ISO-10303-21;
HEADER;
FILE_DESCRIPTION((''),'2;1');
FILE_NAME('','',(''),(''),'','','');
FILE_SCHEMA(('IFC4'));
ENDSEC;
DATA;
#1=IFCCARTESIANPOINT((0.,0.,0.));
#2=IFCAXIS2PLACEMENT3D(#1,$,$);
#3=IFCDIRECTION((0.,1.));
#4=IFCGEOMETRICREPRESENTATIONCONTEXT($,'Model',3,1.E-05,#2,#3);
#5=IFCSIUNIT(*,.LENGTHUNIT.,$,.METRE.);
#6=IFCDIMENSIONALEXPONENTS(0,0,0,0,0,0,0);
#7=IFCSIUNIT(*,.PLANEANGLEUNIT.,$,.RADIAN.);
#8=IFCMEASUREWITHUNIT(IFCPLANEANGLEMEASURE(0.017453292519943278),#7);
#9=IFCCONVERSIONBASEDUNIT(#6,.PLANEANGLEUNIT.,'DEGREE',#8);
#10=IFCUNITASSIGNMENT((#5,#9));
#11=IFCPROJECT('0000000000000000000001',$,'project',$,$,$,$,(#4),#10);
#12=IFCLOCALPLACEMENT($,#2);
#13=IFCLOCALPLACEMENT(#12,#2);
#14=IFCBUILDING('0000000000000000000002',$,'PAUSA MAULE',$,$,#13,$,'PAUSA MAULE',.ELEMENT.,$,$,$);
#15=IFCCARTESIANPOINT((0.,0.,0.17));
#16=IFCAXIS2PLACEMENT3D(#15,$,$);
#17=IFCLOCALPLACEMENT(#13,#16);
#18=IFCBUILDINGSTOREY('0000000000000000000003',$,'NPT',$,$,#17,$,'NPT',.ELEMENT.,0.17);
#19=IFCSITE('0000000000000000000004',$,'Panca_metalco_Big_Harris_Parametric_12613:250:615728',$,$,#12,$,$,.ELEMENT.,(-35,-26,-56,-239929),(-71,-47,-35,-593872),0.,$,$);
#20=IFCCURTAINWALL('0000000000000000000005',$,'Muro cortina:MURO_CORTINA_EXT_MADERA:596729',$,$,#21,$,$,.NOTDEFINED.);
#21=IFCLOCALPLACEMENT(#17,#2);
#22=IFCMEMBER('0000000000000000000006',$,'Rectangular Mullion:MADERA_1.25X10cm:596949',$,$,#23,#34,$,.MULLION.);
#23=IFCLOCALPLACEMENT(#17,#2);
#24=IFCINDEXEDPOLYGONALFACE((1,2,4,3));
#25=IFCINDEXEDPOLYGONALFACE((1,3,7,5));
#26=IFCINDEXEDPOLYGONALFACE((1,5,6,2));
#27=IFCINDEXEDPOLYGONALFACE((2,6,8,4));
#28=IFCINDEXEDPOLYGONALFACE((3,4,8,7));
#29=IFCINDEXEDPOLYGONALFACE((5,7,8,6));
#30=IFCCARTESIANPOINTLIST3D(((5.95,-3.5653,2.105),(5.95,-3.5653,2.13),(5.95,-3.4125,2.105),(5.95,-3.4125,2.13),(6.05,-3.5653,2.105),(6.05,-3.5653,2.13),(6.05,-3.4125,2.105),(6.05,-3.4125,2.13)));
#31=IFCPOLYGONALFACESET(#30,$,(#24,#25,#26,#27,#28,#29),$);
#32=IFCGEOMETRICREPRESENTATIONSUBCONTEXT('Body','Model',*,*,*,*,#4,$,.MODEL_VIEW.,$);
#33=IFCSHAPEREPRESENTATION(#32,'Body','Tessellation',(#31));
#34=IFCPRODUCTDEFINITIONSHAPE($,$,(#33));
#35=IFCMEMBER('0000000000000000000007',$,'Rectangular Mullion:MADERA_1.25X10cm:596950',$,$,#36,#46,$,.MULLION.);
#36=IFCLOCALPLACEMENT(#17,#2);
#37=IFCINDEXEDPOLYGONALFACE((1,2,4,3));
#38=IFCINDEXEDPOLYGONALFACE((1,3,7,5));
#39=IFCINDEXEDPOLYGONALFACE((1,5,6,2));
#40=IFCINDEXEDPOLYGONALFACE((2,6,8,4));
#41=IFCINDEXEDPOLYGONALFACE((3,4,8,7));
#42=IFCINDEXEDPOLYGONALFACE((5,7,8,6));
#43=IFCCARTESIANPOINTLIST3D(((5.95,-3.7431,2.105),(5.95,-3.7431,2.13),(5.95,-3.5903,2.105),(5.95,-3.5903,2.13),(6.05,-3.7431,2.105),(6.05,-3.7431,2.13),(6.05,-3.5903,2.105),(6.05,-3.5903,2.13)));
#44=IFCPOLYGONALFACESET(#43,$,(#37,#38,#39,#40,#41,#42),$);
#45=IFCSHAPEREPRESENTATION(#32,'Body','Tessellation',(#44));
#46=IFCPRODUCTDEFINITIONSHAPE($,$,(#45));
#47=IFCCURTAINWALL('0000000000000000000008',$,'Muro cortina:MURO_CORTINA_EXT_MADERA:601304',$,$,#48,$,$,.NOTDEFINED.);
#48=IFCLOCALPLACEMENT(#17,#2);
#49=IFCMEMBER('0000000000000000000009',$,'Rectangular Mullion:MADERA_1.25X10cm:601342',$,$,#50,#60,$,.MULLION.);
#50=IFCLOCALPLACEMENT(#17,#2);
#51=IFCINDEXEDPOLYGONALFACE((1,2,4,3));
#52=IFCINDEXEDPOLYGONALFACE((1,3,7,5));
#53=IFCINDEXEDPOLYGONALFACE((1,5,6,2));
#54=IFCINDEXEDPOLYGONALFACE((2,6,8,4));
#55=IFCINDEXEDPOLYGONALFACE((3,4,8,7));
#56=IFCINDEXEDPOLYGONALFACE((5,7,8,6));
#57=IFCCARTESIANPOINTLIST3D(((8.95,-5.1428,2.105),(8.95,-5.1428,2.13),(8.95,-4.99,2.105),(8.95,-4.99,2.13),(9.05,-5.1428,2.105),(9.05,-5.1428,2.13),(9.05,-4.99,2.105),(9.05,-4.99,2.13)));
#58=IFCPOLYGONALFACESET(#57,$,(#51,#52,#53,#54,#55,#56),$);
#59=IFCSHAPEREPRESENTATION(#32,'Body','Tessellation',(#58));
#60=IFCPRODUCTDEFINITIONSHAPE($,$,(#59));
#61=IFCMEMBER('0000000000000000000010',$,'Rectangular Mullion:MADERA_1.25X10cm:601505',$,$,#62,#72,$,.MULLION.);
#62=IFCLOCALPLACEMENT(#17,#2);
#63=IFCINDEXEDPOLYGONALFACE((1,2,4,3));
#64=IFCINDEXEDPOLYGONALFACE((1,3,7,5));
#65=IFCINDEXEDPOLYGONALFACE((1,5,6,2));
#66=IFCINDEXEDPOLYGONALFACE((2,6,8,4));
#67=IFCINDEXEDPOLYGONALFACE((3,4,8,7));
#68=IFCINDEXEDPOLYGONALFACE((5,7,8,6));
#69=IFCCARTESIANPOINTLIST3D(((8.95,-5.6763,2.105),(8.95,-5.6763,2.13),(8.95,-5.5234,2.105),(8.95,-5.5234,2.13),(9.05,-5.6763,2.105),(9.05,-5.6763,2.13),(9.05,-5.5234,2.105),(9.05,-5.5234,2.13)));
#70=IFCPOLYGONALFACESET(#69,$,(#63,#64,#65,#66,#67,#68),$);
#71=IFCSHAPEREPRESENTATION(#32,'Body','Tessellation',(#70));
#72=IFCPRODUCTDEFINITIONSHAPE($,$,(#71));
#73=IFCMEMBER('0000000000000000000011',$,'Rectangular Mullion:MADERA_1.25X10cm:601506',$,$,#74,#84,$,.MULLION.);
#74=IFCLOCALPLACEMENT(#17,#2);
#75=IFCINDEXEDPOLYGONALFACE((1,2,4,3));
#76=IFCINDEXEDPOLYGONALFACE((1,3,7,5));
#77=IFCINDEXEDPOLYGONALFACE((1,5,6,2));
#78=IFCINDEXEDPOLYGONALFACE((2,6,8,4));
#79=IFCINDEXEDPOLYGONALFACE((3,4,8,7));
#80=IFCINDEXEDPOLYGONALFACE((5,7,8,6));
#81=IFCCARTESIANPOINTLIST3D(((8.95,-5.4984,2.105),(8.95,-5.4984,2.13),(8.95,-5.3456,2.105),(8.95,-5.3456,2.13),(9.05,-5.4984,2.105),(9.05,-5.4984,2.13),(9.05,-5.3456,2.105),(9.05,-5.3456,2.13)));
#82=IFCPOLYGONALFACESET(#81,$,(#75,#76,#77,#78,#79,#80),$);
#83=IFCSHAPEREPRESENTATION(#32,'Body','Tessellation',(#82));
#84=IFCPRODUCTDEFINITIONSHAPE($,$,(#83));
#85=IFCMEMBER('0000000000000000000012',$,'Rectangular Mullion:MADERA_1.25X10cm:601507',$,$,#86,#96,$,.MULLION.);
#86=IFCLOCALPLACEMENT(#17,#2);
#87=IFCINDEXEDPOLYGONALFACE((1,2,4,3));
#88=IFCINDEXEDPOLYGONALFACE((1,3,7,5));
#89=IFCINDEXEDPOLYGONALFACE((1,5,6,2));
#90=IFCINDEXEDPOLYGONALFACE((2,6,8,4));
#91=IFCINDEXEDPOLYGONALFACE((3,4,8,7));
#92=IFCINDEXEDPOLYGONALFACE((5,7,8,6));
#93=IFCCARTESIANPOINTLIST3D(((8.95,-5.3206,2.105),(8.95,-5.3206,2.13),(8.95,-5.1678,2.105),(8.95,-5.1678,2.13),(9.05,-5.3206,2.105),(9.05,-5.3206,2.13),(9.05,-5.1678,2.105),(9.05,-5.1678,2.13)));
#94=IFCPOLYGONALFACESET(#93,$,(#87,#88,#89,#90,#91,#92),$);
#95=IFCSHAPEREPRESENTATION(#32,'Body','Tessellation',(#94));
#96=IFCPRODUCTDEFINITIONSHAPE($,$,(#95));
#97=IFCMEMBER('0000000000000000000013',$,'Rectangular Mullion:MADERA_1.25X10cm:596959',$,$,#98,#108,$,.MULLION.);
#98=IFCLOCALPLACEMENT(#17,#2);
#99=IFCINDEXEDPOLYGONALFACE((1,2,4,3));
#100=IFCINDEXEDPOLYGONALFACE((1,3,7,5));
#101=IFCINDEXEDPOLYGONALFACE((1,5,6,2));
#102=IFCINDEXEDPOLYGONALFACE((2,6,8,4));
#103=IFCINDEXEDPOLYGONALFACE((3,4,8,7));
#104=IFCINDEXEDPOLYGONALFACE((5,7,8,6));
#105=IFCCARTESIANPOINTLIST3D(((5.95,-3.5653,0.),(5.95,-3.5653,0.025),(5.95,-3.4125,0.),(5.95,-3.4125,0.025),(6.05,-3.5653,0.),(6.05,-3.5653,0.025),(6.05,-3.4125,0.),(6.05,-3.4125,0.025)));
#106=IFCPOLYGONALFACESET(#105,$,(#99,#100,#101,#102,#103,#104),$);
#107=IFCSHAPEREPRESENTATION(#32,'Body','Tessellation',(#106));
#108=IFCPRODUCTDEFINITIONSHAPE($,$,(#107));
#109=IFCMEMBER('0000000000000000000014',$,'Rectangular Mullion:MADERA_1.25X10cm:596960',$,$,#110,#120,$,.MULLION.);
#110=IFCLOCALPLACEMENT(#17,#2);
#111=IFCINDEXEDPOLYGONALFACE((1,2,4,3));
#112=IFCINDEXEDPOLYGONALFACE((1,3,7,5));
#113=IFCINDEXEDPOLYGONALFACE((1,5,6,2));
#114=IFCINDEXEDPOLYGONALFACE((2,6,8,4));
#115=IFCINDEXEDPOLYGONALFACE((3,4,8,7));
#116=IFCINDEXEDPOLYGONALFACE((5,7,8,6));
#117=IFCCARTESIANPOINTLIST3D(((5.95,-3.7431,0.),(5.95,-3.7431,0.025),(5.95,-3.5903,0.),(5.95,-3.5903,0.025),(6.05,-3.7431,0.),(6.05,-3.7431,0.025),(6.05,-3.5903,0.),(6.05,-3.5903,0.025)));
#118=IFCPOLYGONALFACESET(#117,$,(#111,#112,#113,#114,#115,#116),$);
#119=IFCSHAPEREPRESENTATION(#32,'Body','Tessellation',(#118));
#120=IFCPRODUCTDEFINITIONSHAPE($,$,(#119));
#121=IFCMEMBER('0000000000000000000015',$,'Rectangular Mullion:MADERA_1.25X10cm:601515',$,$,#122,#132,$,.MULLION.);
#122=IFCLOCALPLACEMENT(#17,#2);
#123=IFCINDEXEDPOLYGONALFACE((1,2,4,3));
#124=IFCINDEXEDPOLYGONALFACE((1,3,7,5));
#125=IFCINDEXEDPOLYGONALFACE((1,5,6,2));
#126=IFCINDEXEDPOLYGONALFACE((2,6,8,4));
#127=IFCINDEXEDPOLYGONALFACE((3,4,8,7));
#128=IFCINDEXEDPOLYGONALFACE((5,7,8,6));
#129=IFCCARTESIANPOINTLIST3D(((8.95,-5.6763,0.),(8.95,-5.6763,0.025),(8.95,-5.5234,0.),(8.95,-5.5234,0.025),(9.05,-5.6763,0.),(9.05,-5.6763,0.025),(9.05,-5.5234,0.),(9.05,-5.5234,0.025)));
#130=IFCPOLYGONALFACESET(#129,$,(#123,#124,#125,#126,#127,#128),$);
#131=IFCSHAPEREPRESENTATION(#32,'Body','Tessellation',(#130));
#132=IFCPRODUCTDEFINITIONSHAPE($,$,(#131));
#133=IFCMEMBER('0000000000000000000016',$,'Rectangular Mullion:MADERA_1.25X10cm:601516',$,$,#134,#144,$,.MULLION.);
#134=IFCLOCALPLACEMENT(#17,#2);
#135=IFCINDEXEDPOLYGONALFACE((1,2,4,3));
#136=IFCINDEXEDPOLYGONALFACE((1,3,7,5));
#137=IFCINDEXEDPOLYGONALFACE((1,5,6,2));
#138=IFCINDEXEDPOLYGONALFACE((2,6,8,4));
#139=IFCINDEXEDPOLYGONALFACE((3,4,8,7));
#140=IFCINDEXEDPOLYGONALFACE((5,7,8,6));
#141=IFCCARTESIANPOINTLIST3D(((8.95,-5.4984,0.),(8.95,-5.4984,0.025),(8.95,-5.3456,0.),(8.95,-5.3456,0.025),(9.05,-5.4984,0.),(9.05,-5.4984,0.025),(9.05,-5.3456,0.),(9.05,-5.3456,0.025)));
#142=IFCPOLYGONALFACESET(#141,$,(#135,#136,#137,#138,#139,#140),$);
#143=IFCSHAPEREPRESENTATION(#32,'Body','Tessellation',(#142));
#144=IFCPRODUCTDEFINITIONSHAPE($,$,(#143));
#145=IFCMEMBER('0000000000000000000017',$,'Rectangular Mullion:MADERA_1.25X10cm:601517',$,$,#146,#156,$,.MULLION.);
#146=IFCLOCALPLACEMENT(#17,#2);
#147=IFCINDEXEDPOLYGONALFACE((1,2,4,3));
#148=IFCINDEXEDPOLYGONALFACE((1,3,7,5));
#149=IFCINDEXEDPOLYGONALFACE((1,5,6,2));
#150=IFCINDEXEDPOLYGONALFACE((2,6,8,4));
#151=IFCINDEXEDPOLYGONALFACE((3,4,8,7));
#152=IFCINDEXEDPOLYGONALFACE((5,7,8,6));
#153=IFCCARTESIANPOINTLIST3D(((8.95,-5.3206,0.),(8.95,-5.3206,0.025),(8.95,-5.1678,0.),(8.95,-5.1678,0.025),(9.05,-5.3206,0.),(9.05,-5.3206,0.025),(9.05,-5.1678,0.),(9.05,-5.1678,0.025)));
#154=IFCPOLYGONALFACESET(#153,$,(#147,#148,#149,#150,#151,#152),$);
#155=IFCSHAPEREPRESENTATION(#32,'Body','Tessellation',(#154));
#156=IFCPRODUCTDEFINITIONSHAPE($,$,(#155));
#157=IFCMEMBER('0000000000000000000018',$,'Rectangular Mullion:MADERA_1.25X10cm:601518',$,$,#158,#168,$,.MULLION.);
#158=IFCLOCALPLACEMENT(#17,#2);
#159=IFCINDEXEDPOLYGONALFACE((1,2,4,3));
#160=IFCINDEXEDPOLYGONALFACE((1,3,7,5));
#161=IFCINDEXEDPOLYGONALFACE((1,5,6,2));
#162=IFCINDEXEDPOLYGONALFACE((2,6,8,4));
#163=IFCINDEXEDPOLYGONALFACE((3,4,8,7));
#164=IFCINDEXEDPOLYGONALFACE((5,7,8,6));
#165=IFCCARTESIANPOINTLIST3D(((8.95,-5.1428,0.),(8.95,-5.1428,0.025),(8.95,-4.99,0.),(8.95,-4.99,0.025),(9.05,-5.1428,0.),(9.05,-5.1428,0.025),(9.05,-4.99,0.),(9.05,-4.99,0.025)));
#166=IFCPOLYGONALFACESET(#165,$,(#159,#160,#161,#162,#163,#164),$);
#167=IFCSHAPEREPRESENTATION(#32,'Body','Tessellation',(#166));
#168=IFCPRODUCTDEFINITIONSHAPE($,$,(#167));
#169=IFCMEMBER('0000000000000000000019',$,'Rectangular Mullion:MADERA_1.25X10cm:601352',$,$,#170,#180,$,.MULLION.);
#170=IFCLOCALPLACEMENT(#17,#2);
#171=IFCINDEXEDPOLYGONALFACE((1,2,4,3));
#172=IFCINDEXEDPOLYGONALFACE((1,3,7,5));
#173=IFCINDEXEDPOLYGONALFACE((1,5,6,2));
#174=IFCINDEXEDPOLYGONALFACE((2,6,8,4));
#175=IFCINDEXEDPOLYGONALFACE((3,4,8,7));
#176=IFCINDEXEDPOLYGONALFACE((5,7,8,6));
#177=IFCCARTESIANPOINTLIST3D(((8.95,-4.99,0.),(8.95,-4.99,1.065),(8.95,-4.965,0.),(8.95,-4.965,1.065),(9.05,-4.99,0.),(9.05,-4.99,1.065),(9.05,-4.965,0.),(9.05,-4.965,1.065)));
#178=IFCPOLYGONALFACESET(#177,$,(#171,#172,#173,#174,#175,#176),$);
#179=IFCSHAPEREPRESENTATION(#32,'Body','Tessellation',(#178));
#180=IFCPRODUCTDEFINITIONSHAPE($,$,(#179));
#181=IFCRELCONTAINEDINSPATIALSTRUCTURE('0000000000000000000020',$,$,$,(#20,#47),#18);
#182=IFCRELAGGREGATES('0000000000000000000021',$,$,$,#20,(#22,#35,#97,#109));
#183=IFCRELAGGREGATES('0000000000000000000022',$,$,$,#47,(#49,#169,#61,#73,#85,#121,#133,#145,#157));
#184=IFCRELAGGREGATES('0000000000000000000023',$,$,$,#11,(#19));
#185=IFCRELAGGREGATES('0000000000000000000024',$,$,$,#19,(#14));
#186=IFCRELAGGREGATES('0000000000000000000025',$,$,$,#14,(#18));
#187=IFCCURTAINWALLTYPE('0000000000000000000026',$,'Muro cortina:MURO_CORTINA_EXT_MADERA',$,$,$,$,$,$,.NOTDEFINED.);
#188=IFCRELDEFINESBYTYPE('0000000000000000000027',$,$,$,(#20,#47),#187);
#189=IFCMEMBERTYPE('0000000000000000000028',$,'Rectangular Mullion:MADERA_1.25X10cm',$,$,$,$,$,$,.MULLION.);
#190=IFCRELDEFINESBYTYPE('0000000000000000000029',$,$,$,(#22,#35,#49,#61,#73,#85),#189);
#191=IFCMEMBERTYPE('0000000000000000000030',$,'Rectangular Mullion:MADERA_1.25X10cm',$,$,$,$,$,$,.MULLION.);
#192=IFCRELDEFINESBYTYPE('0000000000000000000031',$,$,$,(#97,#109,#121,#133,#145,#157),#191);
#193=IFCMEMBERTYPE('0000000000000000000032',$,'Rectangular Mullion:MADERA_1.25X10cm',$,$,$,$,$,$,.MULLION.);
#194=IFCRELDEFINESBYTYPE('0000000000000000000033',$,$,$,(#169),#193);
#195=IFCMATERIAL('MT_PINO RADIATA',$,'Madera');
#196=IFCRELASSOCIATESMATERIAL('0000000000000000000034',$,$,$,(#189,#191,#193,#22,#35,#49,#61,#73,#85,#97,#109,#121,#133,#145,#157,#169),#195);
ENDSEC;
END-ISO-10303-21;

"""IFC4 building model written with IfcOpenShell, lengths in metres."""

from ifc_helpers import new_model, entity, si_unit, converted_unit, direction, frame, frame_2d, origin, origin_2d_with_axis, place, context, subcontext, project, spatial, rectangle, extrude, source, transform, mapped, material, material_profile, profile_set, profile_usage, type_object, type_shapes, element, aggregate, save


model = new_model("IFC4")

# Units and contexts
model_context = context("Model", 3, precision=1e-05, world=origin(), true_north=direction((0.0, 1.0)))
body_context = subcontext(model_context, "Body", "Model", "MODEL_VIEW")
ifc_project = project(units=[si_unit("LENGTHUNIT", "METRE"), converted_unit("PLANEANGLEUNIT", "DEGREE", entity("IfcPlaneAngleMeasure", 0.017453292519943278), si_unit("PLANEANGLEUNIT", "RADIAN"), dimensions=[0, 0, 0, 0, 0, 0, 0])], contexts=[model_context])

# Site, building, storey
site_placement = place(None, origin())
site = spatial("IfcSite", under=ifc_project, at=site_placement, Name="Panca_metalco_Big_Harris_Parametric_12613:250:615728", CompositionType="ELEMENT", RefLatitude=(-35, -26, -56, -239929), RefLongitude=(-71, -47, -35, -593872), RefElevation=0.0)
building_placement = place(site_placement, origin())
building = spatial("IfcBuilding", under=site, at=building_placement, Name="PAUSA MAULE", LongName="PAUSA MAULE", CompositionType="ELEMENT")
storey_placement = place(building_placement, frame((0.0, 0.0, 0.17)))
storey = spatial("IfcBuildingStorey", under=building, at=storey_placement, Name="NPT", LongName="NPT", CompositionType="ELEMENT", Elevation=0.17)

# Curtain walls, members
curtain_wall_type = type_object("IfcCurtainWallType", Name="Muro cortina:MURO_CORTINA_EXT_MADERA", PredefinedType="NOTDEFINED")
curtain_wall_1_placement = place(storey_placement, frame((0.0, 0.0, -0.17)))
curtain_wall_1 = element("IfcCurtainWall", 1, at=curtain_wall_1_placement, inside=storey, type_object=curtain_wall_type, Name="Muro cortina:MURO_CORTINA_EXT_MADERA:596729", PredefinedType="NOTDEFINED")
ifc_material = material(Name="MT_PINO RADIATA", Category="Madera")
ifc_material_profile = material_profile(ifc_material, rectangle(XDim=0.025, YDim=0.1, at=frame_2d((0.0, 0.0), x_axis=(1.0, 0.0))), Name="MADERA_1.25X10cm")
ifc_profile_set = profile_set([ifc_material_profile], Name="MADERA_1.25X10cm")
ifc_profile_usage = profile_usage(ifc_profile_set)
member_type_1 = type_object("IfcMemberType", Name="Rectangular Mullion:MADERA_1.25X10cm", PredefinedType="MULLION", material=ifc_profile_set)
shared_shape_1 = source(origin(), body_context, "Body", "SweptSolid", [
    extrude(rectangle(XDim=0.025, YDim=0.1, at=frame_2d((0.0, 0.0), x_axis=(1.0, 0.0))), frame((-0.0125, 0.0, -0.1528), z_axis=(0.0, 0.0, 1.0), x_axis=(-1.0, 0.0, 0.0)), (0.0, 0.0, 1.0), 0.1528),
])
type_shapes(member_type_1, [shared_shape_1])
member_1_placement = place(curtain_wall_1_placement, frame((6.0, -3.5653, 2.3), z_axis=(0.0, -1.0, 0.0), x_axis=(0.0, 0.0, 1.0)))
member_1 = element("IfcMember", 2, at=member_1_placement, type_object=member_type_1, material=ifc_profile_usage, Name="Rectangular Mullion:MADERA_1.25X10cm:596949", PredefinedType="MULLION", context=body_context, shape_type="MappedRepresentation", body=[
    mapped(shared_shape_1, transform((0.0, 0.0, 0.0), scale=1.0)),
])
member_2_placement = place(curtain_wall_1_placement, frame((6.0, -3.7431, 2.3), z_axis=(0.0, -1.0, 0.0), x_axis=(0.0, 0.0, 1.0)))
member_2 = element("IfcMember", 3, at=member_2_placement, type_object=member_type_1, material=ifc_profile_usage, Name="Rectangular Mullion:MADERA_1.25X10cm:596950", PredefinedType="MULLION", context=body_context, shape_type="MappedRepresentation", body=[
    mapped(shared_shape_1, transform((0.0, 0.0, 0.0), scale=1.0)),
])
curtain_wall_2_placement = place(storey_placement, frame((0.0, 0.0, -0.17)))
curtain_wall_2 = element("IfcCurtainWall", 4, at=curtain_wall_2_placement, inside=storey, type_object=curtain_wall_type, Name="Muro cortina:MURO_CORTINA_EXT_MADERA:601304", PredefinedType="NOTDEFINED")
member_3_placement = place(curtain_wall_2_placement, frame((9.0, -4.99, 2.3), z_axis=(0.0, 1.0, 0.0), x_axis=(0.0, 0.0, 1.0)))
member_3 = element("IfcMember", 5, at=member_3_placement, type_object=member_type_1, material=ifc_profile_usage, Name="Rectangular Mullion:MADERA_1.25X10cm:601342", PredefinedType="MULLION", context=body_context, shape_type="MappedRepresentation", body=[
    mapped(shared_shape_1, transform((0.0, 0.0, 0.0), scale=1.0)),
])
member_4_placement = place(curtain_wall_2_placement, frame((9.0, -5.5234, 2.3), z_axis=(0.0, 1.0, 0.0), x_axis=(0.0, 0.0, 1.0)))
member_4 = element("IfcMember", 6, at=member_4_placement, type_object=member_type_1, material=ifc_profile_usage, Name="Rectangular Mullion:MADERA_1.25X10cm:601505", PredefinedType="MULLION", context=body_context, shape_type="MappedRepresentation", body=[
    mapped(shared_shape_1, transform((0.0, 0.0, 0.0), scale=1.0)),
])
member_5_placement = place(curtain_wall_2_placement, frame((9.0, -5.3456, 2.3), z_axis=(0.0, 1.0, 0.0), x_axis=(0.0, 0.0, 1.0)))
member_5 = element("IfcMember", 7, at=member_5_placement, type_object=member_type_1, material=ifc_profile_usage, Name="Rectangular Mullion:MADERA_1.25X10cm:601506", PredefinedType="MULLION", context=body_context, shape_type="MappedRepresentation", body=[
    mapped(shared_shape_1, transform((0.0, 0.0, 0.0), scale=1.0)),
])
member_6_placement = place(curtain_wall_2_placement, frame((9.0, -5.1678, 2.3), z_axis=(0.0, 1.0, 0.0), x_axis=(0.0, 0.0, 1.0)))
member_6 = element("IfcMember", 8, at=member_6_placement, type_object=member_type_1, material=ifc_profile_usage, Name="Rectangular Mullion:MADERA_1.25X10cm:601507", PredefinedType="MULLION", context=body_context, shape_type="MappedRepresentation", body=[
    mapped(shared_shape_1, transform((0.0, 0.0, 0.0), scale=1.0)),
])

# Members
member_type_2 = type_object("IfcMemberType", Name="Rectangular Mullion:MADERA_1.25X10cm", PredefinedType="MULLION", material=ifc_profile_set)
shared_shape_2 = source(origin(), body_context, "Body", "SweptSolid", [
    extrude(rectangle(XDim=0.025, YDim=0.1, at=frame_2d((0.0, 0.0), x_axis=(1.0, 0.0))), frame((-0.0125, 0.0, -0.1528), z_axis=(0.0, 0.0, 1.0), x_axis=(-1.0, 0.0, 0.0)), (0.0, 0.0, 1.0), 0.1528),
])
type_shapes(member_type_2, [shared_shape_2])
member_7_placement = place(curtain_wall_1_placement, frame((6.0, -3.4125, 0.17), z_axis=(0.0, 1.0, 0.0), x_axis=(0.0, 0.0, -1.0)))
member_7 = element("IfcMember", 9, at=member_7_placement, type_object=member_type_2, material=ifc_profile_usage, Name="Rectangular Mullion:MADERA_1.25X10cm:596959", PredefinedType="MULLION", context=body_context, shape_type="MappedRepresentation", body=[
    mapped(shared_shape_2, transform((0.0, 0.0, 0.0), scale=1.0)),
])
member_8_placement = place(curtain_wall_1_placement, frame((6.0, -3.5903, 0.17), z_axis=(0.0, 1.0, 0.0), x_axis=(0.0, 0.0, -1.0)))
member_8 = element("IfcMember", 10, at=member_8_placement, type_object=member_type_2, material=ifc_profile_usage, Name="Rectangular Mullion:MADERA_1.25X10cm:596960", PredefinedType="MULLION", context=body_context, shape_type="MappedRepresentation", body=[
    mapped(shared_shape_2, transform((0.0, 0.0, 0.0), scale=1.0)),
])
member_9_placement = place(curtain_wall_2_placement, frame((9.0, -5.6763, 0.17), z_axis=(0.0, -1.0, 0.0), x_axis=(0.0, 0.0, -1.0)))
member_9 = element("IfcMember", 11, at=member_9_placement, type_object=member_type_2, material=ifc_profile_usage, Name="Rectangular Mullion:MADERA_1.25X10cm:601515", PredefinedType="MULLION", context=body_context, shape_type="MappedRepresentation", body=[
    mapped(shared_shape_2, transform((0.0, 0.0, 0.0), scale=1.0)),
])
member_10_placement = place(curtain_wall_2_placement, frame((9.0, -5.4984, 0.17), z_axis=(0.0, -1.0, 0.0), x_axis=(0.0, 0.0, -1.0)))
member_10 = element("IfcMember", 12, at=member_10_placement, type_object=member_type_2, material=ifc_profile_usage, Name="Rectangular Mullion:MADERA_1.25X10cm:601516", PredefinedType="MULLION", context=body_context, shape_type="MappedRepresentation", body=[
    mapped(shared_shape_2, transform((0.0, 0.0, 0.0), scale=1.0)),
])
member_11_placement = place(curtain_wall_2_placement, frame((9.0, -5.3206, 0.17), z_axis=(0.0, -1.0, 0.0), x_axis=(0.0, 0.0, -1.0)))
member_11 = element("IfcMember", 13, at=member_11_placement, type_object=member_type_2, material=ifc_profile_usage, Name="Rectangular Mullion:MADERA_1.25X10cm:601517", PredefinedType="MULLION", context=body_context, shape_type="MappedRepresentation", body=[
    mapped(shared_shape_2, transform((0.0, 0.0, 0.0), scale=1.0)),
])
member_12_placement = place(curtain_wall_2_placement, frame((9.0, -5.1428, 0.17), z_axis=(0.0, -1.0, 0.0), x_axis=(0.0, 0.0, -1.0)))
member_12 = element("IfcMember", 14, at=member_12_placement, type_object=member_type_2, material=ifc_profile_usage, Name="Rectangular Mullion:MADERA_1.25X10cm:601518", PredefinedType="MULLION", context=body_context, shape_type="MappedRepresentation", body=[
    mapped(shared_shape_2, transform((0.0, 0.0, 0.0), scale=1.0)),
])
member_type_3 = type_object("IfcMemberType", Name="Rectangular Mullion:MADERA_1.25X10cm", PredefinedType="MULLION", material=ifc_profile_set)
shared_shape_3 = source(origin(), body_context, "Body", "SweptSolid", [
    extrude(rectangle(XDim=0.025, YDim=0.1, at=origin_2d_with_axis()), frame((-0.0125, 0.0, -1.065), z_axis=(0.0, 0.0, 1.0), x_axis=(-1.0, 0.0, 0.0)), (0.0, 0.0, 1.0), 1.065),
])
type_shapes(member_type_3, [shared_shape_3])
member_13_placement = place(curtain_wall_2_placement, frame((9.0, -4.965, 0.17), z_axis=(0.0, 0.0, -1.0), x_axis=(0.0, 1.0, 0.0)))
member_13 = element("IfcMember", 15, at=member_13_placement, type_object=member_type_3, material=ifc_profile_usage, Name="Rectangular Mullion:MADERA_1.25X10cm:601352", PredefinedType="MULLION", context=body_context, shape_type="MappedRepresentation", body=[
    mapped(shared_shape_3, transform((0.0, 0.0, 0.0), scale=1.0)),
])
aggregate(curtain_wall_1, [member_1, member_2, member_7, member_8])
aggregate(curtain_wall_2, [member_3, member_13, member_4, member_5, member_6, member_9, member_10, member_11, member_12])

save(model, "model.ifc")
